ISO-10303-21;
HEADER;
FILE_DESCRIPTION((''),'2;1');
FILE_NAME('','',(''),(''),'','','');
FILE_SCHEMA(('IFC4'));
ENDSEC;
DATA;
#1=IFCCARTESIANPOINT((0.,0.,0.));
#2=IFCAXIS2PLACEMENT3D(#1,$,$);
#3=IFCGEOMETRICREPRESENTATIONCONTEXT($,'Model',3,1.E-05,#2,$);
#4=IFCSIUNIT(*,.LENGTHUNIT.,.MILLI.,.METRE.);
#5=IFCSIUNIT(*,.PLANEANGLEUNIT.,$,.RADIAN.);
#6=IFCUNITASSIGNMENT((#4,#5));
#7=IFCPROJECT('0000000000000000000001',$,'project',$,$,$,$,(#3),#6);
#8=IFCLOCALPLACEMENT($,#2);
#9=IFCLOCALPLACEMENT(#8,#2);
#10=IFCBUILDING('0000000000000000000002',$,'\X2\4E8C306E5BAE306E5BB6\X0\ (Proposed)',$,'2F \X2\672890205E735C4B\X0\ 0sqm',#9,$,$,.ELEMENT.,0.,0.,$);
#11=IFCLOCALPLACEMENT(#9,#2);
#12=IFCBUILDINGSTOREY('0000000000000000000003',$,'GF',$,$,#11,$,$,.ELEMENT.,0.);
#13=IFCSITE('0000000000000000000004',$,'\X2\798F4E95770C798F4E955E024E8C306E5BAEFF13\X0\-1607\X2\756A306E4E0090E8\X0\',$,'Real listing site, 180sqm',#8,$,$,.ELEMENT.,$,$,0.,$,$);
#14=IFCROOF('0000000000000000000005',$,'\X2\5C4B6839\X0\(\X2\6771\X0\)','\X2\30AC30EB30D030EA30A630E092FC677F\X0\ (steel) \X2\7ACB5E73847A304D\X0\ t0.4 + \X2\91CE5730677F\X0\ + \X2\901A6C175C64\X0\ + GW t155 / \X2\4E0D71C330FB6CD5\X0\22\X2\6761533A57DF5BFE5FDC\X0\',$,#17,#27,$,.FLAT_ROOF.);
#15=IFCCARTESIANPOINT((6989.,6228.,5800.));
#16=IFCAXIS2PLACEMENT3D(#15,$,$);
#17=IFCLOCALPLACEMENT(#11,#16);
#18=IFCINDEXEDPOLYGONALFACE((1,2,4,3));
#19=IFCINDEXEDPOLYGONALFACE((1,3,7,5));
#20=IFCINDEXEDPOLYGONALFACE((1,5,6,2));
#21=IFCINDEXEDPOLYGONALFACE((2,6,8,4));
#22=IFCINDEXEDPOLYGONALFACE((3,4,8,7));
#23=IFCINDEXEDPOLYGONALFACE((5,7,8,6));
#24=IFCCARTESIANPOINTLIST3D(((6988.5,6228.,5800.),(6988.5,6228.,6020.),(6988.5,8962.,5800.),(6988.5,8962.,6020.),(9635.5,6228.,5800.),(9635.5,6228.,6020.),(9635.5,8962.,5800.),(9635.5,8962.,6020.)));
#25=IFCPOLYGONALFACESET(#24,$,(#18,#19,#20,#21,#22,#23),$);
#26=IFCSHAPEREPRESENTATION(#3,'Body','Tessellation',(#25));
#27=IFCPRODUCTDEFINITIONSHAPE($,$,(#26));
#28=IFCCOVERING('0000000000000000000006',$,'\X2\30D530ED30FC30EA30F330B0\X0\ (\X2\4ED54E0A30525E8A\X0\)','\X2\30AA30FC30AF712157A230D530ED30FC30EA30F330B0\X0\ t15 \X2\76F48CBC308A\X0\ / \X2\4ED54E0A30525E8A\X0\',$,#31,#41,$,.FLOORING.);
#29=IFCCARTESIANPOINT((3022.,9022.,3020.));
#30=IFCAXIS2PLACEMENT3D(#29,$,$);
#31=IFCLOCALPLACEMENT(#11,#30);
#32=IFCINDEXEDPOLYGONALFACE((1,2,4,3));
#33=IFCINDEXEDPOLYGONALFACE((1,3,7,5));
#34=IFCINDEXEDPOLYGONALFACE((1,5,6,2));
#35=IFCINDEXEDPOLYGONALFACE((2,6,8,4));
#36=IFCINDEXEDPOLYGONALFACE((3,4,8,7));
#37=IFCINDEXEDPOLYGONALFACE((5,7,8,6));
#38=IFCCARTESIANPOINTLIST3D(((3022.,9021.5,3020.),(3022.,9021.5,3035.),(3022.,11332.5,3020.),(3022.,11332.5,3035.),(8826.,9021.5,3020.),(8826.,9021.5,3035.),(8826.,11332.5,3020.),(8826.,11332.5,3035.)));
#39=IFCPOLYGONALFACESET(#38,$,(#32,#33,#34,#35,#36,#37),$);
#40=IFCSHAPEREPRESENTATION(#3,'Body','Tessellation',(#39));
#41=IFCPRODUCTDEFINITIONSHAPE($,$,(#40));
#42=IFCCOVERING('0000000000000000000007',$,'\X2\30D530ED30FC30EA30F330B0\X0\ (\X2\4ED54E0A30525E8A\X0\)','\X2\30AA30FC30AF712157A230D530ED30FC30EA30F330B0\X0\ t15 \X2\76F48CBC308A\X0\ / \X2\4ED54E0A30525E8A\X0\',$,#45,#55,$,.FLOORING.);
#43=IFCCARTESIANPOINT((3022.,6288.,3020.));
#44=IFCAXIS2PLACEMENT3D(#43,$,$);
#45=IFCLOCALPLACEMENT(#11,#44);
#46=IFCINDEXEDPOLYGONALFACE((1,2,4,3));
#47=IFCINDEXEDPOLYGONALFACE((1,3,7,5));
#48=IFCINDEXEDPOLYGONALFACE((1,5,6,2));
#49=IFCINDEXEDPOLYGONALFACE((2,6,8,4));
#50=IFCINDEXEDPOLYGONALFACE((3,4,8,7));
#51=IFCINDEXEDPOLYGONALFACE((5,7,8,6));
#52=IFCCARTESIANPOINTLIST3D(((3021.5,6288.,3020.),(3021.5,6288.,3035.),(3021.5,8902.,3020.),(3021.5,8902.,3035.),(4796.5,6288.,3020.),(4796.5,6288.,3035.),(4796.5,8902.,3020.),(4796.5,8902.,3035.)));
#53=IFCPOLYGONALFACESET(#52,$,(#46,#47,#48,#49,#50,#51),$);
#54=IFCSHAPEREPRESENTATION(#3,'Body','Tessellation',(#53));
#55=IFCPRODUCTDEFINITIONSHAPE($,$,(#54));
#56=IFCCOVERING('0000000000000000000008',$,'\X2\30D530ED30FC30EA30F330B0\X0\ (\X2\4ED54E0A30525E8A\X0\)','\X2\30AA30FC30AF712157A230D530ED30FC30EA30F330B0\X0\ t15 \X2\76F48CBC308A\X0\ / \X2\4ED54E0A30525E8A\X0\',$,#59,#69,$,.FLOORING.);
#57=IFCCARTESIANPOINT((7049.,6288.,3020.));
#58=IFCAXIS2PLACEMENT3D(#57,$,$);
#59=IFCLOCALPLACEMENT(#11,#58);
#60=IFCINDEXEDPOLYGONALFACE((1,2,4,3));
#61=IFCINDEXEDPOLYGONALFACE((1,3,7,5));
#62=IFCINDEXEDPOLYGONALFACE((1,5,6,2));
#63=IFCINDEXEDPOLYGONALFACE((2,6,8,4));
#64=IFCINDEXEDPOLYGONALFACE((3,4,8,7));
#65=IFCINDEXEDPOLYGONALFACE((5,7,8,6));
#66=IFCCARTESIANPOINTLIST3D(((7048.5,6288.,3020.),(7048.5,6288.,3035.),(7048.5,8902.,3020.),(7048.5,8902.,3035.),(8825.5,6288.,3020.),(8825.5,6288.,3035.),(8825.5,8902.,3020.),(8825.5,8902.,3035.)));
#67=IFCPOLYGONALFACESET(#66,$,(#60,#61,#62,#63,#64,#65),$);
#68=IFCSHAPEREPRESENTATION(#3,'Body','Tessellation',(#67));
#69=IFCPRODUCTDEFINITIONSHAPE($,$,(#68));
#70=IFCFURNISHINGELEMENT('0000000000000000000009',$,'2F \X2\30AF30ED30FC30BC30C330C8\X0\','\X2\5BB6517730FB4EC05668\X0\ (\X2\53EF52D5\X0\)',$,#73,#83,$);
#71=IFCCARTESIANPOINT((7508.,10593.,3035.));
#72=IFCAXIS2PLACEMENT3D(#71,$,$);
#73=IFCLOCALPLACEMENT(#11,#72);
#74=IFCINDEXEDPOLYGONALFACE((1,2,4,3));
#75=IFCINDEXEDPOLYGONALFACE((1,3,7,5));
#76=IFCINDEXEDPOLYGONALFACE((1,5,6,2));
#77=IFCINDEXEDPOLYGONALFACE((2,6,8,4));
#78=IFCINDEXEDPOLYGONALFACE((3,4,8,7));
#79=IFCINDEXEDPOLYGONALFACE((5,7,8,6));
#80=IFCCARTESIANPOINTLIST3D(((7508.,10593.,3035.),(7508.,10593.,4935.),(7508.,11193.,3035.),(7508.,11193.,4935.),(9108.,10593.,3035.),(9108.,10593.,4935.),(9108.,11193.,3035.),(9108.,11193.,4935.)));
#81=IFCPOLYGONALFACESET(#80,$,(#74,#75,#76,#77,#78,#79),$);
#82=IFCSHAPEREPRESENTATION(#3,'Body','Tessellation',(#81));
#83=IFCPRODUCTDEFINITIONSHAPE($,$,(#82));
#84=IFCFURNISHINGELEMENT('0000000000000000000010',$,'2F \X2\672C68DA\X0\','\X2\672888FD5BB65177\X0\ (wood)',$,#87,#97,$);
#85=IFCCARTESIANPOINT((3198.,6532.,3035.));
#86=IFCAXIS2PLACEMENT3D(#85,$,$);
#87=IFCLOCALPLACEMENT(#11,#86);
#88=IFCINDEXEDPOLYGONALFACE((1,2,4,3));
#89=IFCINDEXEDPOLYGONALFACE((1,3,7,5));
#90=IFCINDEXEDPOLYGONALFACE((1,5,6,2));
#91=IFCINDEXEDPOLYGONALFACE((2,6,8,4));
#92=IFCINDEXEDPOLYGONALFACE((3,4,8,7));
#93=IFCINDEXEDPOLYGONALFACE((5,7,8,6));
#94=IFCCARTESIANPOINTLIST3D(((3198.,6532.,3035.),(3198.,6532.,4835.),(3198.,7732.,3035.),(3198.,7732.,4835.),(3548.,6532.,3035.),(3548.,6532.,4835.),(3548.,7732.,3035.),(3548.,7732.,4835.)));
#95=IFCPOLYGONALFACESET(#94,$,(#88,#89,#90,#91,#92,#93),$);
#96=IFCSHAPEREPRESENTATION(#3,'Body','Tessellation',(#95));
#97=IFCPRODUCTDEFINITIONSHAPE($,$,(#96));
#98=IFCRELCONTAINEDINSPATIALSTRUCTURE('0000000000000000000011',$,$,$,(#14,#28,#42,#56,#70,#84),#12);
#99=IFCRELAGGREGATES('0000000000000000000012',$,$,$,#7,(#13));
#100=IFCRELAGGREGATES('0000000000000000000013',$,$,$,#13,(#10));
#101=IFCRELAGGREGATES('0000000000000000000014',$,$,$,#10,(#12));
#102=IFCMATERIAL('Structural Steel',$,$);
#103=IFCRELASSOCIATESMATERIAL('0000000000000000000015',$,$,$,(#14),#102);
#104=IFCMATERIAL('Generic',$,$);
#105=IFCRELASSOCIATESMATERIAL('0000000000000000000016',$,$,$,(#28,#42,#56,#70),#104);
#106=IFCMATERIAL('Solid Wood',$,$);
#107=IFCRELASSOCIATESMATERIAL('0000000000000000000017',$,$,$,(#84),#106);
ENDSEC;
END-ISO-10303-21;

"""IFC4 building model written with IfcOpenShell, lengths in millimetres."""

from ifc_helpers import new_model, si_unit, frame, frame_2d, origin, place, context, project, spatial, rectangle, extrude, material, element, save


model = new_model("IFC4")

# Units and contexts
model_context = context("Model", 3, precision=1e-05, world=origin())
ifc_project = project(units=[si_unit("LENGTHUNIT", "METRE", prefix="MILLI"), si_unit("PLANEANGLEUNIT", "RADIAN")], contexts=[model_context])

# Site, building, storey
site_placement = place(None, origin())
site = spatial("IfcSite", under=ifc_project, at=site_placement, Name="福井県福井市二の宮３-1607番の一部", ObjectType="Real listing site, 180sqm", CompositionType="ELEMENT", RefElevation=0.0)
building_placement = place(site_placement, origin())
building = spatial("IfcBuilding", under=site, at=building_placement, Name="二の宮の家 (Proposed)", ObjectType="2F 木造平屋 0sqm", CompositionType="ELEMENT", ElevationOfRefHeight=0.0, ElevationOfTerrain=0.0)
storey_placement = place(building_placement, origin())
storey = spatial("IfcBuildingStorey", under=building, at=storey_placement, Name="GF", CompositionType="ELEMENT", Elevation=0.0)

# Shared definitions
ifc_material_1 = material(Name="Solid Wood")

# Roof
ifc_material_2 = material(Name="Structural Steel")
roof_1_placement = place(storey_placement, frame((6989.0, 6228.0, 5800.0)))
element("IfcRoof", 1, at=roof_1_placement, inside=storey, material=ifc_material_2, Name="屋根(東)", Description="ガルバリウム鋼板 (steel) 立平葺き t0.4 + 野地板 + 通気層 + GW t155 / 不燃・法22条区域対応", PredefinedType="FLAT_ROOF", context=model_context, shape_type="SweptSolid", body=[
    extrude(rectangle(XDim=2647.0, YDim=2734.0, at=frame_2d((1323.0, 1367.0))), frame((6989.0, 6228.0, 5800.0)), (0.0, 0.0, 1.0), 220.0),
])

# Coverings
ifc_material_3 = material(Name="Generic")
covering_1_placement = place(storey_placement, frame((3022.0, 9022.0, 3020.0)))
element("IfcCovering", 2, at=covering_1_placement, inside=storey, material=ifc_material_3, Name="フローリング (仕上げ床)", Description="オーク無垢フローリング t15 直貼り / 仕上げ床", PredefinedType="FLOORING", context=model_context, shape_type="SweptSolid", body=[
    extrude(rectangle(XDim=5804.0, YDim=2311.0, at=frame_2d((2902.0, 1155.0))), frame((3022.0, 9022.0, 3020.0)), (0.0, 0.0, 1.0), 15.0),
])
covering_2_placement = place(storey_placement, frame((3022.0, 6288.0, 3020.0)))
element("IfcCovering", 3, at=covering_2_placement, inside=storey, material=ifc_material_3, Name="フローリング (仕上げ床)", Description="オーク無垢フローリング t15 直貼り / 仕上げ床", PredefinedType="FLOORING", context=model_context, shape_type="SweptSolid", body=[
    extrude(rectangle(XDim=1775.0, YDim=2614.0, at=frame_2d((887.0, 1307.0))), frame((3022.0, 6288.0, 3020.0)), (0.0, 0.0, 1.0), 15.0),
])
covering_3_placement = place(storey_placement, frame((7049.0, 6288.0, 3020.0)))
element("IfcCovering", 4, at=covering_3_placement, inside=storey, material=ifc_material_3, Name="フローリング (仕上げ床)", Description="オーク無垢フローリング t15 直貼り / 仕上げ床", PredefinedType="FLOORING", context=model_context, shape_type="SweptSolid", body=[
    extrude(rectangle(XDim=1777.0, YDim=2614.0, at=frame_2d((888.0, 1307.0))), frame((7049.0, 6288.0, 3020.0)), (0.0, 0.0, 1.0), 15.0),
])

# Furnishing elements
furnishing_1_placement = place(storey_placement, frame((7508.0, 10593.0, 3035.0)))
element("IfcFurnishingElement", 5, at=furnishing_1_placement, inside=storey, material=ifc_material_3, Name="2F クローゼット", Description="家具・什器 (可動)", context=model_context, shape_type="SweptSolid", body=[
    extrude(rectangle(XDim=1600.0, YDim=600.0, at=frame_2d((800.0, 300.0))), frame((7508.0, 10593.0, 3035.0)), (0.0, 0.0, 1.0), 1900.0),
])
furnishing_2_placement = place(storey_placement, frame((3198.0, 6532.0, 3035.0)))
element("IfcFurnishingElement", 6, at=furnishing_2_placement, inside=storey, material=ifc_material_1, Name="2F 本棚", Description="木製家具 (wood)", context=model_context, shape_type="SweptSolid", body=[
    extrude(rectangle(XDim=350.0, YDim=1200.0, at=frame_2d((175.0, 600.0))), frame((3198.0, 6532.0, 3035.0)), (0.0, 0.0, 1.0), 1800.0),
])

save(model, "model.ifc")
